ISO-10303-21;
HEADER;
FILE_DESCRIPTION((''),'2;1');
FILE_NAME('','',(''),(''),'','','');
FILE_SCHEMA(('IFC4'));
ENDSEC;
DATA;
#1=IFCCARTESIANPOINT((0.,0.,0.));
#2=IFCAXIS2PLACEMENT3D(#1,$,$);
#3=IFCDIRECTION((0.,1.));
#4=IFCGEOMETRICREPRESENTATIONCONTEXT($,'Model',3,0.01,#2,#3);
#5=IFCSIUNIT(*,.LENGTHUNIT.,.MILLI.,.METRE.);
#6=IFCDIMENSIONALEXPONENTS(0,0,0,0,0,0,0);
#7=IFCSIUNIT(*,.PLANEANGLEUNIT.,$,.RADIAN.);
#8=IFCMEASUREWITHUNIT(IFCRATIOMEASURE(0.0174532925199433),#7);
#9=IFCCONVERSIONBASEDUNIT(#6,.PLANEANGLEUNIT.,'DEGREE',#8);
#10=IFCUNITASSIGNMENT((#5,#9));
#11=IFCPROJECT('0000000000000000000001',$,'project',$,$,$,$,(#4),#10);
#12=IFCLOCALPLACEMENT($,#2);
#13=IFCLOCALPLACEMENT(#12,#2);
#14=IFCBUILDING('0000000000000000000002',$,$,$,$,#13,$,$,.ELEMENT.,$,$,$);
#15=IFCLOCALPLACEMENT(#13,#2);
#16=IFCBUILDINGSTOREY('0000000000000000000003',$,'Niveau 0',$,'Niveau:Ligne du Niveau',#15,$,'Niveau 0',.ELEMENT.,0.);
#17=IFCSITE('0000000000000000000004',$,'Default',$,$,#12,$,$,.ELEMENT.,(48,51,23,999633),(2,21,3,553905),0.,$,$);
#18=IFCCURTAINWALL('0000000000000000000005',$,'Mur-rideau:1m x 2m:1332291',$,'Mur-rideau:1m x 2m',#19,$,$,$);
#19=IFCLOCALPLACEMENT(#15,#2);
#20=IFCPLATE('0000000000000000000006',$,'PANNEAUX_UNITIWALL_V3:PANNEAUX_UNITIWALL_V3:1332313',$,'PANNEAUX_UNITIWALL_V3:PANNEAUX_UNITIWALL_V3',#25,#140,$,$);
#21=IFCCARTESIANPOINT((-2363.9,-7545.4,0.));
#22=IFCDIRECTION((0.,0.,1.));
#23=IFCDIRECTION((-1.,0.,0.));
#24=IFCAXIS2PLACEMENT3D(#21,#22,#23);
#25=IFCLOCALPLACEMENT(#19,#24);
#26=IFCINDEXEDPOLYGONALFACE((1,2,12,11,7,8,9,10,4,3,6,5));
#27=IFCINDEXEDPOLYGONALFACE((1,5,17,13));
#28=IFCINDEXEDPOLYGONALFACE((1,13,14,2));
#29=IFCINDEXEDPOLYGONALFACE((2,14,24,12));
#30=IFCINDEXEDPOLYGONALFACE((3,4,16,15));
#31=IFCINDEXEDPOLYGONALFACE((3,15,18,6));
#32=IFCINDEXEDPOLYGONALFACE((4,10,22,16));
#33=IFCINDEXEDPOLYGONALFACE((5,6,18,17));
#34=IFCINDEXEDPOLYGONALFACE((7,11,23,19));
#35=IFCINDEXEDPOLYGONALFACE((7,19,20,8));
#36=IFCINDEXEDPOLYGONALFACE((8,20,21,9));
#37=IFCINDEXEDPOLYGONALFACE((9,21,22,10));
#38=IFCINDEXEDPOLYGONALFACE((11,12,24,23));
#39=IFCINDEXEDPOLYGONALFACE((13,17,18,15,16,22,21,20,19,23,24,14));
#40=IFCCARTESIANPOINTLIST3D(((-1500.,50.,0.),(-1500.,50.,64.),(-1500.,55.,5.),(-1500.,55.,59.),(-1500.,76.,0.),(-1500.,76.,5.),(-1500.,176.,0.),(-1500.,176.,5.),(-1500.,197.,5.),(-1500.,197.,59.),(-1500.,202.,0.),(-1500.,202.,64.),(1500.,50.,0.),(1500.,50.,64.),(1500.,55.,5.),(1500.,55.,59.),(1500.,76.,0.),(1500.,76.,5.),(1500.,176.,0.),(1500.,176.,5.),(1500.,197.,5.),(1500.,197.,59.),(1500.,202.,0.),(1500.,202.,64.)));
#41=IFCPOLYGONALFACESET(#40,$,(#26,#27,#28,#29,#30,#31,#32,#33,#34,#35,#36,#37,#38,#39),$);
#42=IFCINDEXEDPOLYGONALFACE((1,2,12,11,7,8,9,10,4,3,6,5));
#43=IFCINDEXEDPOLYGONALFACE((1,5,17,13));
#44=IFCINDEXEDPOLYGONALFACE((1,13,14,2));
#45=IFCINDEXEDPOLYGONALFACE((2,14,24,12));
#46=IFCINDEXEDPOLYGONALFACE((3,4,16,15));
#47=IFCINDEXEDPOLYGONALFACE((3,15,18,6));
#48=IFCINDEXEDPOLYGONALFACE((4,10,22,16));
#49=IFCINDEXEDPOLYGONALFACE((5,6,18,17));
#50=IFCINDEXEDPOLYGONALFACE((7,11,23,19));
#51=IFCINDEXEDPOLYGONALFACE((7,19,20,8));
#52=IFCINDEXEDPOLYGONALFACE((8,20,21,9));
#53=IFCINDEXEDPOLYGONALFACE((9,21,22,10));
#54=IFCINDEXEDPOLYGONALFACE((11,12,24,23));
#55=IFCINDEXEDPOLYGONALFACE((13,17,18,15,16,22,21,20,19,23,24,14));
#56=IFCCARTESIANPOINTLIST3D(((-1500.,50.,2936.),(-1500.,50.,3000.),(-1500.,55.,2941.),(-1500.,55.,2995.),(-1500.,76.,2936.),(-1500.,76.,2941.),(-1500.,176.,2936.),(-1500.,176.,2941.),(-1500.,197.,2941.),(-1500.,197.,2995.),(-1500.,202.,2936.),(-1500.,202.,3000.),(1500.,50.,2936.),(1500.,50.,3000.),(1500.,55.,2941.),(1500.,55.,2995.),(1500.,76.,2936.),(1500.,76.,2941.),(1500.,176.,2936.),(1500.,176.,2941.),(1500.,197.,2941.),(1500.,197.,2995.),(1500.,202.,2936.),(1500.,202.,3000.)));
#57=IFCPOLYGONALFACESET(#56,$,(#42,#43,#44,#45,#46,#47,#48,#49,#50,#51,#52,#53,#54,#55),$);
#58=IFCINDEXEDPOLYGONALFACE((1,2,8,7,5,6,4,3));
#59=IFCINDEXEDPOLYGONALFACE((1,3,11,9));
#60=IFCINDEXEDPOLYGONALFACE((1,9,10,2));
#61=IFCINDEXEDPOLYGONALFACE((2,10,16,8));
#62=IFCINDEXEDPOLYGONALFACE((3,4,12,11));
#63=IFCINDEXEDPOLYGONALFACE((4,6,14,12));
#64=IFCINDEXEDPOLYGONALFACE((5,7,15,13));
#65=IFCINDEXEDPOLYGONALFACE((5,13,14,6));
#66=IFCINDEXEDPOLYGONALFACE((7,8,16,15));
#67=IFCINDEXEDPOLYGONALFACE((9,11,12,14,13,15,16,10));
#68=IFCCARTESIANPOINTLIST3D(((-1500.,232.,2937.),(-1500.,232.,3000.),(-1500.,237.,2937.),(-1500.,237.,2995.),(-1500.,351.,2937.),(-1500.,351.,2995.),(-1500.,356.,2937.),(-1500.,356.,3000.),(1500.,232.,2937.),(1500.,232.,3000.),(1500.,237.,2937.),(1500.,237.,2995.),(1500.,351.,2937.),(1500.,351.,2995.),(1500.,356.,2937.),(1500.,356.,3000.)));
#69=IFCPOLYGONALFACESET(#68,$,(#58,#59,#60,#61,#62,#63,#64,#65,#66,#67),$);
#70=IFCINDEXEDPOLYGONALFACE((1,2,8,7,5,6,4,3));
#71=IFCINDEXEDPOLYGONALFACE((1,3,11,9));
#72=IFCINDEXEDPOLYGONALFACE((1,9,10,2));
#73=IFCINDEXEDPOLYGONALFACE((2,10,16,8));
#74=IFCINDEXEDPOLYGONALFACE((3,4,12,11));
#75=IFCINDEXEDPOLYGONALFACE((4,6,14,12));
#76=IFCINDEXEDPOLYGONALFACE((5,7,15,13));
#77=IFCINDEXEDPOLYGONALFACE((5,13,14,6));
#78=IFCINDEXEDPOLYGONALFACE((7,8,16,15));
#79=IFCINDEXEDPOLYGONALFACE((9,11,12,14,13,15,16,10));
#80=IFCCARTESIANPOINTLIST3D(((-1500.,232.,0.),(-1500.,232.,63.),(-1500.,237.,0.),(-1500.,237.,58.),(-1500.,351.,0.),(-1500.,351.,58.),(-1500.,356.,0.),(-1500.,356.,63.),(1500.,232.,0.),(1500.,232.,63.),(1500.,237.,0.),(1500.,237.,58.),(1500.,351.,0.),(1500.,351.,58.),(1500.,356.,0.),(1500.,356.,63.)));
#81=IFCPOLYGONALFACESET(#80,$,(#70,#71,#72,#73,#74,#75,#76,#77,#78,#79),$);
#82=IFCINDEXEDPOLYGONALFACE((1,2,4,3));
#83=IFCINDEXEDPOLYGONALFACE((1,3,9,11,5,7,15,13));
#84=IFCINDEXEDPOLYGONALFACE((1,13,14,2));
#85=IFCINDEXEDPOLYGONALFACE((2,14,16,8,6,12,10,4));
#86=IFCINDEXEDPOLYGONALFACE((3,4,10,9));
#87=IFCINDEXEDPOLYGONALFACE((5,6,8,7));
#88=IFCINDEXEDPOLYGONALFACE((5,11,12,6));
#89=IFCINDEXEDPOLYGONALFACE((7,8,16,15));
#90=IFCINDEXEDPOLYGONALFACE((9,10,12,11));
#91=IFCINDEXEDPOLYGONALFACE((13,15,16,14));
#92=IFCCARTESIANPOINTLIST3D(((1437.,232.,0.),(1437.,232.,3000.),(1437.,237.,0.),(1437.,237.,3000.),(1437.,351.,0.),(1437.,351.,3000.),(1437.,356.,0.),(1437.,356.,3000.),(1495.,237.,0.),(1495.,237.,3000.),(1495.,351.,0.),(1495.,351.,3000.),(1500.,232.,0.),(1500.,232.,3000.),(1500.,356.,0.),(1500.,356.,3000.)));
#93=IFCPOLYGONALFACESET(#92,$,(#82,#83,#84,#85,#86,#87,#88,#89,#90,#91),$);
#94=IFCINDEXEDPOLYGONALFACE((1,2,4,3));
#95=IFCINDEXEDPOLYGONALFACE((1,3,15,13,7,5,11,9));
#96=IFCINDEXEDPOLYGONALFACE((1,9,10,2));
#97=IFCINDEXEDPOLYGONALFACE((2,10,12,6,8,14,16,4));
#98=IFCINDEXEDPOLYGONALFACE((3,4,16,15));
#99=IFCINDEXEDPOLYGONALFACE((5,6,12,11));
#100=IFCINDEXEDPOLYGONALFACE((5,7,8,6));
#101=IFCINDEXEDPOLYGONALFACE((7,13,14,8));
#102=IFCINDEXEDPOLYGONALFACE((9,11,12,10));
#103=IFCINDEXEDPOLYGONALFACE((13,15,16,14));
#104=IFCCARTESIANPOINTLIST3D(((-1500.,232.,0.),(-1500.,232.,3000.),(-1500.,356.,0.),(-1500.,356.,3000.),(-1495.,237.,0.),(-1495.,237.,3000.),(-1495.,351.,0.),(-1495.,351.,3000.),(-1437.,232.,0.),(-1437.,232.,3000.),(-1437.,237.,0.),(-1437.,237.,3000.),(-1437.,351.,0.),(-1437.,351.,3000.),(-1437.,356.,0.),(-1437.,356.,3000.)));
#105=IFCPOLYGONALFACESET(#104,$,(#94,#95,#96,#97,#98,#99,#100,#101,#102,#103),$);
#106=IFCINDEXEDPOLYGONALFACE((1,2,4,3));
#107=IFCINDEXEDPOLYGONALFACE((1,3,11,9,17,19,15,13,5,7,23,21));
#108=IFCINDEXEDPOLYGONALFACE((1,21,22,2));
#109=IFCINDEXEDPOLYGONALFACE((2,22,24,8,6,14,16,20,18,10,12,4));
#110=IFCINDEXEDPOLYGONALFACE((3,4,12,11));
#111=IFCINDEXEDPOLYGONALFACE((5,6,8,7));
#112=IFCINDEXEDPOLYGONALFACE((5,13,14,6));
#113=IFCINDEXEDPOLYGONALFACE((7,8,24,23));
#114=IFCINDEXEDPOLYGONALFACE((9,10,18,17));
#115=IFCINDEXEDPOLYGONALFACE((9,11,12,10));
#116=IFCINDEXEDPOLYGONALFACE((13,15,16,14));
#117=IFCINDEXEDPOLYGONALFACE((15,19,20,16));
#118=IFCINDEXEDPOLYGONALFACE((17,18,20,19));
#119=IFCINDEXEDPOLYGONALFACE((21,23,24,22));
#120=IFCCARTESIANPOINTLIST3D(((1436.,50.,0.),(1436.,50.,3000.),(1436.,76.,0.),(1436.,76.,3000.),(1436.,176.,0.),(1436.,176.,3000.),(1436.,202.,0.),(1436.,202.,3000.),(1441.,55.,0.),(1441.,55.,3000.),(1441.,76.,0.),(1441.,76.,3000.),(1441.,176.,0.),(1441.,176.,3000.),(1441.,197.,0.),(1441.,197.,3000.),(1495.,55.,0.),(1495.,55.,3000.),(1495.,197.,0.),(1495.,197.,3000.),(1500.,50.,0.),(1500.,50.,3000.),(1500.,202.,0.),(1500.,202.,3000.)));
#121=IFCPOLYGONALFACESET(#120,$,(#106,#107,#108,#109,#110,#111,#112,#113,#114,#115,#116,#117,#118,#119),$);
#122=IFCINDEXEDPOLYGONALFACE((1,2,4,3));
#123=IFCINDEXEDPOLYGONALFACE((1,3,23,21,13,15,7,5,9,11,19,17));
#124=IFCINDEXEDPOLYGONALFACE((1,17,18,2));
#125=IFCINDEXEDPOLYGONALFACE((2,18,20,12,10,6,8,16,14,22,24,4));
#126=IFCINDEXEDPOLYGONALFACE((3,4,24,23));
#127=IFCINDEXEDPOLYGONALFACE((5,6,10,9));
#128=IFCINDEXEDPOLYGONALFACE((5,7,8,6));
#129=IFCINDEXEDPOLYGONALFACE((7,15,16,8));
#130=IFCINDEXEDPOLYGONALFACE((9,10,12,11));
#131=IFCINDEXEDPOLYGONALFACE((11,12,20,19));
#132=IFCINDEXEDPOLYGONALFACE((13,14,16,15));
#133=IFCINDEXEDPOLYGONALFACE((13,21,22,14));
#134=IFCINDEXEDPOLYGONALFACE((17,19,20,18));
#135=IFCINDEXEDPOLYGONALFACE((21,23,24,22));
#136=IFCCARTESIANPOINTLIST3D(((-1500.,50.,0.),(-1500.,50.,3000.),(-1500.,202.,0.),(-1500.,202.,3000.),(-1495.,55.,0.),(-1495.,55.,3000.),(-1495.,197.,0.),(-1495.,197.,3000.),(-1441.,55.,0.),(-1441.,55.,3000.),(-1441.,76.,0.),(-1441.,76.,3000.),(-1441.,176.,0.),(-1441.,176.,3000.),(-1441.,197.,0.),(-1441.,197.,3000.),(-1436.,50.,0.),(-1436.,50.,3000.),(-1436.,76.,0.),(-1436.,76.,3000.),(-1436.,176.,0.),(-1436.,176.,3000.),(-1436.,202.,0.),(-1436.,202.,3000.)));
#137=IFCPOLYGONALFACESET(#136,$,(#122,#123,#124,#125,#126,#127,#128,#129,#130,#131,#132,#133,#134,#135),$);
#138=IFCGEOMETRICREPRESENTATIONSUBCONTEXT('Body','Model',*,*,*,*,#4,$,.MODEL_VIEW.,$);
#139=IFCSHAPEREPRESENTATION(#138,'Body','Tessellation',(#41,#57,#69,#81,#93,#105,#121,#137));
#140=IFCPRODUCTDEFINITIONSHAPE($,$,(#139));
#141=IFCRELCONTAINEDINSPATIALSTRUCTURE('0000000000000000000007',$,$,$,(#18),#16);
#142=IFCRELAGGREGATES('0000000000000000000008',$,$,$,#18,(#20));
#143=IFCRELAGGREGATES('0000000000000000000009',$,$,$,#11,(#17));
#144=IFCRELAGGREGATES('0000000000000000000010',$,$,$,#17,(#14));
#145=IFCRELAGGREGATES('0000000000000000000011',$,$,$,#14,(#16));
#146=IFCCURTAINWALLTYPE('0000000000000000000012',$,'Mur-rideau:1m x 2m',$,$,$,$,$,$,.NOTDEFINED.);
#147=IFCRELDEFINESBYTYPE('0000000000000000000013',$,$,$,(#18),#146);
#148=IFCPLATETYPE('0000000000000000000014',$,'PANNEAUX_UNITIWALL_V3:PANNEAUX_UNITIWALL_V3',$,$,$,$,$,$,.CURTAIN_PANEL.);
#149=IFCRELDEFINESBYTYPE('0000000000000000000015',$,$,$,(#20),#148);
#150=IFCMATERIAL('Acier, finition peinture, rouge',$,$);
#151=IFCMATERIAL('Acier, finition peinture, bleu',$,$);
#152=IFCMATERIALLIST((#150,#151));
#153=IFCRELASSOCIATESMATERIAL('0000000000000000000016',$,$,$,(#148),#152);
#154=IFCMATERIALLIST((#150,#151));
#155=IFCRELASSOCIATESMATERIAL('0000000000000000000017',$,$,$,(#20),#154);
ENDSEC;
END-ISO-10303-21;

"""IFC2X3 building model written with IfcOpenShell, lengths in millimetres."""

from ifc_helpers import new_model, entity, si_unit, converted_unit, direction, frame, origin, place, context, subcontext, project, spatial, polyline, outline, extrude, source, transform, mapped, material, material_list, type_object, type_shapes, element, aggregate, save


model = new_model("IFC2X3")

# Units and contexts
model_context = context("Model", 3, precision=0.01, world=origin(), true_north=direction((0.0, 1.0)))
body_context = subcontext(model_context, "Body", "Model", "MODEL_VIEW")
ifc_project = project(units=[si_unit("LENGTHUNIT", "METRE", prefix="MILLI"), converted_unit("PLANEANGLEUNIT", "DEGREE", entity("IfcRatioMeasure", 0.0174532925199433), si_unit("PLANEANGLEUNIT", "RADIAN"), dimensions=[0, 0, 0, 0, 0, 0, 0])], contexts=[model_context])

# Site, building, storey
site_placement = place(None, origin())
site = spatial("IfcSite", under=ifc_project, at=site_placement, Name="Default", CompositionType="ELEMENT", RefLatitude=(48, 51, 23, 999633), RefLongitude=(2, 21, 3, 553905), RefElevation=0.0)
building_placement = place(site_placement, origin())
building = spatial("IfcBuilding", under=site, at=building_placement, CompositionType="ELEMENT")
storey_placement = place(building_placement, origin())
storey = spatial("IfcBuildingStorey", under=building, at=storey_placement, Name="Niveau 0", ObjectType="Niveau:Ligne du Niveau", LongName="Niveau 0", CompositionType="ELEMENT", Elevation=0.0)

# Curtain wall, plate
curtain_wall_type_1 = type_object("IfcCurtainWallType", Name="Mur-rideau:1m x 2m", PredefinedType="NOTDEFINED")
curtain_wall_1_placement = place(storey_placement, origin())
curtain_wall_1 = element("IfcCurtainWall", 1, at=curtain_wall_1_placement, inside=storey, type_object=curtain_wall_type_1, Name="Mur-rideau:1m x 2m:1332291", ObjectType="Mur-rideau:1m x 2m")
ifc_material_1 = material(Name="Acier, finition peinture, bleu")
ifc_material_2 = material(Name="Acier, finition peinture, rouge")
ifc_material_list_1 = material_list([ifc_material_2, ifc_material_1])
plate_type_1 = type_object("IfcPlateType", Name="PANNEAUX_UNITIWALL_V3:PANNEAUX_UNITIWALL_V3", PredefinedType="CURTAIN_PANEL", material=ifc_material_list_1)
shared_shape_1 = source(origin(), body_context, "Body", "SweptSolid", [
    extrude(outline(polyline([(-41.8, -76.0), (22.2, -76.0), (22.2, -50.0), (17.2, -50.0), (17.2, -71.0), (-36.8, -71.0), (-36.8, 71.0), (17.2, 71.0), (17.2, 50.0), (22.2, 50.0), (22.2, 76.0), (-41.8, 76.0), (-41.8, -76.0)])), frame((-1500.0, 126.0, 22.2), z_axis=(1.0, 0.0, 0.0), x_axis=(0.0, 0.0, -1.0)), (0.0, 0.0, 1.0), 3000.0),
    extrude(outline(polyline([(-41.8, -76.0), (22.2, -76.0), (22.2, -50.0), (17.2, -50.0), (17.2, -71.0), (-36.8, -71.0), (-36.8, 71.0), (17.2, 71.0), (17.2, 50.0), (22.2, 50.0), (22.2, 76.0), (-41.8, 76.0), (-41.8, -76.0)])), frame((-1500.0, 126.0, 2958.2), z_axis=(1.0, 0.0, 0.0), x_axis=(0.0, 0.0, -1.0)), (0.0, 0.0, 1.0), 3000.0),
    extrude(outline(polyline([(-62.0, -32.8), (62.0, -32.8), (62.0, 30.2), (57.0, 30.2), (57.0, -27.8), (-57.0, -27.8), (-57.0, 30.2), (-62.0, 30.2), (-62.0, -32.8)])), frame((-1500.0, 294.0, 2967.3), z_axis=(1.0, 0.0, 0.0), x_axis=(0.0, -1.0, 0.0)), (0.0, 0.0, 1.0), 3000.0),
    extrude(outline(polyline([(-62.0, -32.8), (62.0, -32.8), (62.0, 30.2), (57.0, 30.2), (57.0, -27.8), (-57.0, -27.8), (-57.0, 30.2), (-62.0, 30.2), (-62.0, -32.8)])), frame((-1500.0, 294.0, 30.3), z_axis=(1.0, 0.0, 0.0), x_axis=(0.0, -1.0, 0.0)), (0.0, 0.0, 1.0), 3000.0),
    extrude(outline(polyline([(-62.0, -32.8), (62.0, -32.8), (62.0, 30.2), (57.0, 30.2), (57.0, -27.8), (-57.0, -27.8), (-57.0, 30.2), (-62.0, 30.2), (-62.0, -32.8)])), frame((1467.3, 294.0, 0.0), z_axis=(0.0, 0.0, 1.0), x_axis=(0.0, 1.0, 0.0)), (0.0, 0.0, 1.0), 3000.0),
    extrude(outline(polyline([(-32.8, -62.0), (30.2, -62.0), (30.2, -57.0), (-27.8, -57.0), (-27.8, 57.0), (30.2, 57.0), (30.2, 62.0), (-32.8, 62.0), (-32.8, -62.0)])), frame((-1467.3, 294.0, 0.0)), (0.0, 0.0, 1.0), 3000.0),
    extrude(outline(polyline([(-76.0, -41.8), (76.0, -41.8), (76.0, 22.2), (50.0, 22.2), (50.0, 17.2), (71.0, 17.2), (71.0, -36.8), (-71.0, -36.8), (-71.0, 17.2), (-50.0, 17.2), (-50.0, 22.2), (-76.0, 22.2), (-76.0, -41.8)])), frame((1458.2, 126.0, 0.0), z_axis=(0.0, 0.0, 1.0), x_axis=(0.0, 1.0, 0.0)), (0.0, 0.0, 1.0), 3000.0),
    extrude(outline(polyline([(-76.0, -41.8), (76.0, -41.8), (76.0, 22.2), (50.0, 22.2), (50.0, 17.2), (71.0, 17.2), (71.0, -36.8), (-71.0, -36.8), (-71.0, 17.2), (-50.0, 17.2), (-50.0, 22.2), (-76.0, 22.2), (-76.0, -41.8)])), frame((-1458.2, 126.0, 0.0), z_axis=(0.0, 0.0, 1.0), x_axis=(0.0, -1.0, 0.0)), (0.0, 0.0, 1.0), 3000.0),
])
type_shapes(plate_type_1, [shared_shape_1])
ifc_material_list_2 = material_list([ifc_material_2, ifc_material_1])
plate_1_placement = place(curtain_wall_1_placement, frame((-2363.9, -7545.4, 0.0), z_axis=(0.0, 0.0, 1.0), x_axis=(-1.0, 0.0, 0.0)))
plate_1 = element("IfcPlate", 2, at=plate_1_placement, type_object=plate_type_1, material=ifc_material_list_2, Name="PANNEAUX_UNITIWALL_V3:PANNEAUX_UNITIWALL_V3:1332313", ObjectType="PANNEAUX_UNITIWALL_V3:PANNEAUX_UNITIWALL_V3", context=body_context, shape_type="MappedRepresentation", body=[
    mapped(shared_shape_1, transform((0.0, 0.0, 0.0), scale=1.0)),
])
aggregate(curtain_wall_1, [plate_1])

save(model, "model.ifc")
